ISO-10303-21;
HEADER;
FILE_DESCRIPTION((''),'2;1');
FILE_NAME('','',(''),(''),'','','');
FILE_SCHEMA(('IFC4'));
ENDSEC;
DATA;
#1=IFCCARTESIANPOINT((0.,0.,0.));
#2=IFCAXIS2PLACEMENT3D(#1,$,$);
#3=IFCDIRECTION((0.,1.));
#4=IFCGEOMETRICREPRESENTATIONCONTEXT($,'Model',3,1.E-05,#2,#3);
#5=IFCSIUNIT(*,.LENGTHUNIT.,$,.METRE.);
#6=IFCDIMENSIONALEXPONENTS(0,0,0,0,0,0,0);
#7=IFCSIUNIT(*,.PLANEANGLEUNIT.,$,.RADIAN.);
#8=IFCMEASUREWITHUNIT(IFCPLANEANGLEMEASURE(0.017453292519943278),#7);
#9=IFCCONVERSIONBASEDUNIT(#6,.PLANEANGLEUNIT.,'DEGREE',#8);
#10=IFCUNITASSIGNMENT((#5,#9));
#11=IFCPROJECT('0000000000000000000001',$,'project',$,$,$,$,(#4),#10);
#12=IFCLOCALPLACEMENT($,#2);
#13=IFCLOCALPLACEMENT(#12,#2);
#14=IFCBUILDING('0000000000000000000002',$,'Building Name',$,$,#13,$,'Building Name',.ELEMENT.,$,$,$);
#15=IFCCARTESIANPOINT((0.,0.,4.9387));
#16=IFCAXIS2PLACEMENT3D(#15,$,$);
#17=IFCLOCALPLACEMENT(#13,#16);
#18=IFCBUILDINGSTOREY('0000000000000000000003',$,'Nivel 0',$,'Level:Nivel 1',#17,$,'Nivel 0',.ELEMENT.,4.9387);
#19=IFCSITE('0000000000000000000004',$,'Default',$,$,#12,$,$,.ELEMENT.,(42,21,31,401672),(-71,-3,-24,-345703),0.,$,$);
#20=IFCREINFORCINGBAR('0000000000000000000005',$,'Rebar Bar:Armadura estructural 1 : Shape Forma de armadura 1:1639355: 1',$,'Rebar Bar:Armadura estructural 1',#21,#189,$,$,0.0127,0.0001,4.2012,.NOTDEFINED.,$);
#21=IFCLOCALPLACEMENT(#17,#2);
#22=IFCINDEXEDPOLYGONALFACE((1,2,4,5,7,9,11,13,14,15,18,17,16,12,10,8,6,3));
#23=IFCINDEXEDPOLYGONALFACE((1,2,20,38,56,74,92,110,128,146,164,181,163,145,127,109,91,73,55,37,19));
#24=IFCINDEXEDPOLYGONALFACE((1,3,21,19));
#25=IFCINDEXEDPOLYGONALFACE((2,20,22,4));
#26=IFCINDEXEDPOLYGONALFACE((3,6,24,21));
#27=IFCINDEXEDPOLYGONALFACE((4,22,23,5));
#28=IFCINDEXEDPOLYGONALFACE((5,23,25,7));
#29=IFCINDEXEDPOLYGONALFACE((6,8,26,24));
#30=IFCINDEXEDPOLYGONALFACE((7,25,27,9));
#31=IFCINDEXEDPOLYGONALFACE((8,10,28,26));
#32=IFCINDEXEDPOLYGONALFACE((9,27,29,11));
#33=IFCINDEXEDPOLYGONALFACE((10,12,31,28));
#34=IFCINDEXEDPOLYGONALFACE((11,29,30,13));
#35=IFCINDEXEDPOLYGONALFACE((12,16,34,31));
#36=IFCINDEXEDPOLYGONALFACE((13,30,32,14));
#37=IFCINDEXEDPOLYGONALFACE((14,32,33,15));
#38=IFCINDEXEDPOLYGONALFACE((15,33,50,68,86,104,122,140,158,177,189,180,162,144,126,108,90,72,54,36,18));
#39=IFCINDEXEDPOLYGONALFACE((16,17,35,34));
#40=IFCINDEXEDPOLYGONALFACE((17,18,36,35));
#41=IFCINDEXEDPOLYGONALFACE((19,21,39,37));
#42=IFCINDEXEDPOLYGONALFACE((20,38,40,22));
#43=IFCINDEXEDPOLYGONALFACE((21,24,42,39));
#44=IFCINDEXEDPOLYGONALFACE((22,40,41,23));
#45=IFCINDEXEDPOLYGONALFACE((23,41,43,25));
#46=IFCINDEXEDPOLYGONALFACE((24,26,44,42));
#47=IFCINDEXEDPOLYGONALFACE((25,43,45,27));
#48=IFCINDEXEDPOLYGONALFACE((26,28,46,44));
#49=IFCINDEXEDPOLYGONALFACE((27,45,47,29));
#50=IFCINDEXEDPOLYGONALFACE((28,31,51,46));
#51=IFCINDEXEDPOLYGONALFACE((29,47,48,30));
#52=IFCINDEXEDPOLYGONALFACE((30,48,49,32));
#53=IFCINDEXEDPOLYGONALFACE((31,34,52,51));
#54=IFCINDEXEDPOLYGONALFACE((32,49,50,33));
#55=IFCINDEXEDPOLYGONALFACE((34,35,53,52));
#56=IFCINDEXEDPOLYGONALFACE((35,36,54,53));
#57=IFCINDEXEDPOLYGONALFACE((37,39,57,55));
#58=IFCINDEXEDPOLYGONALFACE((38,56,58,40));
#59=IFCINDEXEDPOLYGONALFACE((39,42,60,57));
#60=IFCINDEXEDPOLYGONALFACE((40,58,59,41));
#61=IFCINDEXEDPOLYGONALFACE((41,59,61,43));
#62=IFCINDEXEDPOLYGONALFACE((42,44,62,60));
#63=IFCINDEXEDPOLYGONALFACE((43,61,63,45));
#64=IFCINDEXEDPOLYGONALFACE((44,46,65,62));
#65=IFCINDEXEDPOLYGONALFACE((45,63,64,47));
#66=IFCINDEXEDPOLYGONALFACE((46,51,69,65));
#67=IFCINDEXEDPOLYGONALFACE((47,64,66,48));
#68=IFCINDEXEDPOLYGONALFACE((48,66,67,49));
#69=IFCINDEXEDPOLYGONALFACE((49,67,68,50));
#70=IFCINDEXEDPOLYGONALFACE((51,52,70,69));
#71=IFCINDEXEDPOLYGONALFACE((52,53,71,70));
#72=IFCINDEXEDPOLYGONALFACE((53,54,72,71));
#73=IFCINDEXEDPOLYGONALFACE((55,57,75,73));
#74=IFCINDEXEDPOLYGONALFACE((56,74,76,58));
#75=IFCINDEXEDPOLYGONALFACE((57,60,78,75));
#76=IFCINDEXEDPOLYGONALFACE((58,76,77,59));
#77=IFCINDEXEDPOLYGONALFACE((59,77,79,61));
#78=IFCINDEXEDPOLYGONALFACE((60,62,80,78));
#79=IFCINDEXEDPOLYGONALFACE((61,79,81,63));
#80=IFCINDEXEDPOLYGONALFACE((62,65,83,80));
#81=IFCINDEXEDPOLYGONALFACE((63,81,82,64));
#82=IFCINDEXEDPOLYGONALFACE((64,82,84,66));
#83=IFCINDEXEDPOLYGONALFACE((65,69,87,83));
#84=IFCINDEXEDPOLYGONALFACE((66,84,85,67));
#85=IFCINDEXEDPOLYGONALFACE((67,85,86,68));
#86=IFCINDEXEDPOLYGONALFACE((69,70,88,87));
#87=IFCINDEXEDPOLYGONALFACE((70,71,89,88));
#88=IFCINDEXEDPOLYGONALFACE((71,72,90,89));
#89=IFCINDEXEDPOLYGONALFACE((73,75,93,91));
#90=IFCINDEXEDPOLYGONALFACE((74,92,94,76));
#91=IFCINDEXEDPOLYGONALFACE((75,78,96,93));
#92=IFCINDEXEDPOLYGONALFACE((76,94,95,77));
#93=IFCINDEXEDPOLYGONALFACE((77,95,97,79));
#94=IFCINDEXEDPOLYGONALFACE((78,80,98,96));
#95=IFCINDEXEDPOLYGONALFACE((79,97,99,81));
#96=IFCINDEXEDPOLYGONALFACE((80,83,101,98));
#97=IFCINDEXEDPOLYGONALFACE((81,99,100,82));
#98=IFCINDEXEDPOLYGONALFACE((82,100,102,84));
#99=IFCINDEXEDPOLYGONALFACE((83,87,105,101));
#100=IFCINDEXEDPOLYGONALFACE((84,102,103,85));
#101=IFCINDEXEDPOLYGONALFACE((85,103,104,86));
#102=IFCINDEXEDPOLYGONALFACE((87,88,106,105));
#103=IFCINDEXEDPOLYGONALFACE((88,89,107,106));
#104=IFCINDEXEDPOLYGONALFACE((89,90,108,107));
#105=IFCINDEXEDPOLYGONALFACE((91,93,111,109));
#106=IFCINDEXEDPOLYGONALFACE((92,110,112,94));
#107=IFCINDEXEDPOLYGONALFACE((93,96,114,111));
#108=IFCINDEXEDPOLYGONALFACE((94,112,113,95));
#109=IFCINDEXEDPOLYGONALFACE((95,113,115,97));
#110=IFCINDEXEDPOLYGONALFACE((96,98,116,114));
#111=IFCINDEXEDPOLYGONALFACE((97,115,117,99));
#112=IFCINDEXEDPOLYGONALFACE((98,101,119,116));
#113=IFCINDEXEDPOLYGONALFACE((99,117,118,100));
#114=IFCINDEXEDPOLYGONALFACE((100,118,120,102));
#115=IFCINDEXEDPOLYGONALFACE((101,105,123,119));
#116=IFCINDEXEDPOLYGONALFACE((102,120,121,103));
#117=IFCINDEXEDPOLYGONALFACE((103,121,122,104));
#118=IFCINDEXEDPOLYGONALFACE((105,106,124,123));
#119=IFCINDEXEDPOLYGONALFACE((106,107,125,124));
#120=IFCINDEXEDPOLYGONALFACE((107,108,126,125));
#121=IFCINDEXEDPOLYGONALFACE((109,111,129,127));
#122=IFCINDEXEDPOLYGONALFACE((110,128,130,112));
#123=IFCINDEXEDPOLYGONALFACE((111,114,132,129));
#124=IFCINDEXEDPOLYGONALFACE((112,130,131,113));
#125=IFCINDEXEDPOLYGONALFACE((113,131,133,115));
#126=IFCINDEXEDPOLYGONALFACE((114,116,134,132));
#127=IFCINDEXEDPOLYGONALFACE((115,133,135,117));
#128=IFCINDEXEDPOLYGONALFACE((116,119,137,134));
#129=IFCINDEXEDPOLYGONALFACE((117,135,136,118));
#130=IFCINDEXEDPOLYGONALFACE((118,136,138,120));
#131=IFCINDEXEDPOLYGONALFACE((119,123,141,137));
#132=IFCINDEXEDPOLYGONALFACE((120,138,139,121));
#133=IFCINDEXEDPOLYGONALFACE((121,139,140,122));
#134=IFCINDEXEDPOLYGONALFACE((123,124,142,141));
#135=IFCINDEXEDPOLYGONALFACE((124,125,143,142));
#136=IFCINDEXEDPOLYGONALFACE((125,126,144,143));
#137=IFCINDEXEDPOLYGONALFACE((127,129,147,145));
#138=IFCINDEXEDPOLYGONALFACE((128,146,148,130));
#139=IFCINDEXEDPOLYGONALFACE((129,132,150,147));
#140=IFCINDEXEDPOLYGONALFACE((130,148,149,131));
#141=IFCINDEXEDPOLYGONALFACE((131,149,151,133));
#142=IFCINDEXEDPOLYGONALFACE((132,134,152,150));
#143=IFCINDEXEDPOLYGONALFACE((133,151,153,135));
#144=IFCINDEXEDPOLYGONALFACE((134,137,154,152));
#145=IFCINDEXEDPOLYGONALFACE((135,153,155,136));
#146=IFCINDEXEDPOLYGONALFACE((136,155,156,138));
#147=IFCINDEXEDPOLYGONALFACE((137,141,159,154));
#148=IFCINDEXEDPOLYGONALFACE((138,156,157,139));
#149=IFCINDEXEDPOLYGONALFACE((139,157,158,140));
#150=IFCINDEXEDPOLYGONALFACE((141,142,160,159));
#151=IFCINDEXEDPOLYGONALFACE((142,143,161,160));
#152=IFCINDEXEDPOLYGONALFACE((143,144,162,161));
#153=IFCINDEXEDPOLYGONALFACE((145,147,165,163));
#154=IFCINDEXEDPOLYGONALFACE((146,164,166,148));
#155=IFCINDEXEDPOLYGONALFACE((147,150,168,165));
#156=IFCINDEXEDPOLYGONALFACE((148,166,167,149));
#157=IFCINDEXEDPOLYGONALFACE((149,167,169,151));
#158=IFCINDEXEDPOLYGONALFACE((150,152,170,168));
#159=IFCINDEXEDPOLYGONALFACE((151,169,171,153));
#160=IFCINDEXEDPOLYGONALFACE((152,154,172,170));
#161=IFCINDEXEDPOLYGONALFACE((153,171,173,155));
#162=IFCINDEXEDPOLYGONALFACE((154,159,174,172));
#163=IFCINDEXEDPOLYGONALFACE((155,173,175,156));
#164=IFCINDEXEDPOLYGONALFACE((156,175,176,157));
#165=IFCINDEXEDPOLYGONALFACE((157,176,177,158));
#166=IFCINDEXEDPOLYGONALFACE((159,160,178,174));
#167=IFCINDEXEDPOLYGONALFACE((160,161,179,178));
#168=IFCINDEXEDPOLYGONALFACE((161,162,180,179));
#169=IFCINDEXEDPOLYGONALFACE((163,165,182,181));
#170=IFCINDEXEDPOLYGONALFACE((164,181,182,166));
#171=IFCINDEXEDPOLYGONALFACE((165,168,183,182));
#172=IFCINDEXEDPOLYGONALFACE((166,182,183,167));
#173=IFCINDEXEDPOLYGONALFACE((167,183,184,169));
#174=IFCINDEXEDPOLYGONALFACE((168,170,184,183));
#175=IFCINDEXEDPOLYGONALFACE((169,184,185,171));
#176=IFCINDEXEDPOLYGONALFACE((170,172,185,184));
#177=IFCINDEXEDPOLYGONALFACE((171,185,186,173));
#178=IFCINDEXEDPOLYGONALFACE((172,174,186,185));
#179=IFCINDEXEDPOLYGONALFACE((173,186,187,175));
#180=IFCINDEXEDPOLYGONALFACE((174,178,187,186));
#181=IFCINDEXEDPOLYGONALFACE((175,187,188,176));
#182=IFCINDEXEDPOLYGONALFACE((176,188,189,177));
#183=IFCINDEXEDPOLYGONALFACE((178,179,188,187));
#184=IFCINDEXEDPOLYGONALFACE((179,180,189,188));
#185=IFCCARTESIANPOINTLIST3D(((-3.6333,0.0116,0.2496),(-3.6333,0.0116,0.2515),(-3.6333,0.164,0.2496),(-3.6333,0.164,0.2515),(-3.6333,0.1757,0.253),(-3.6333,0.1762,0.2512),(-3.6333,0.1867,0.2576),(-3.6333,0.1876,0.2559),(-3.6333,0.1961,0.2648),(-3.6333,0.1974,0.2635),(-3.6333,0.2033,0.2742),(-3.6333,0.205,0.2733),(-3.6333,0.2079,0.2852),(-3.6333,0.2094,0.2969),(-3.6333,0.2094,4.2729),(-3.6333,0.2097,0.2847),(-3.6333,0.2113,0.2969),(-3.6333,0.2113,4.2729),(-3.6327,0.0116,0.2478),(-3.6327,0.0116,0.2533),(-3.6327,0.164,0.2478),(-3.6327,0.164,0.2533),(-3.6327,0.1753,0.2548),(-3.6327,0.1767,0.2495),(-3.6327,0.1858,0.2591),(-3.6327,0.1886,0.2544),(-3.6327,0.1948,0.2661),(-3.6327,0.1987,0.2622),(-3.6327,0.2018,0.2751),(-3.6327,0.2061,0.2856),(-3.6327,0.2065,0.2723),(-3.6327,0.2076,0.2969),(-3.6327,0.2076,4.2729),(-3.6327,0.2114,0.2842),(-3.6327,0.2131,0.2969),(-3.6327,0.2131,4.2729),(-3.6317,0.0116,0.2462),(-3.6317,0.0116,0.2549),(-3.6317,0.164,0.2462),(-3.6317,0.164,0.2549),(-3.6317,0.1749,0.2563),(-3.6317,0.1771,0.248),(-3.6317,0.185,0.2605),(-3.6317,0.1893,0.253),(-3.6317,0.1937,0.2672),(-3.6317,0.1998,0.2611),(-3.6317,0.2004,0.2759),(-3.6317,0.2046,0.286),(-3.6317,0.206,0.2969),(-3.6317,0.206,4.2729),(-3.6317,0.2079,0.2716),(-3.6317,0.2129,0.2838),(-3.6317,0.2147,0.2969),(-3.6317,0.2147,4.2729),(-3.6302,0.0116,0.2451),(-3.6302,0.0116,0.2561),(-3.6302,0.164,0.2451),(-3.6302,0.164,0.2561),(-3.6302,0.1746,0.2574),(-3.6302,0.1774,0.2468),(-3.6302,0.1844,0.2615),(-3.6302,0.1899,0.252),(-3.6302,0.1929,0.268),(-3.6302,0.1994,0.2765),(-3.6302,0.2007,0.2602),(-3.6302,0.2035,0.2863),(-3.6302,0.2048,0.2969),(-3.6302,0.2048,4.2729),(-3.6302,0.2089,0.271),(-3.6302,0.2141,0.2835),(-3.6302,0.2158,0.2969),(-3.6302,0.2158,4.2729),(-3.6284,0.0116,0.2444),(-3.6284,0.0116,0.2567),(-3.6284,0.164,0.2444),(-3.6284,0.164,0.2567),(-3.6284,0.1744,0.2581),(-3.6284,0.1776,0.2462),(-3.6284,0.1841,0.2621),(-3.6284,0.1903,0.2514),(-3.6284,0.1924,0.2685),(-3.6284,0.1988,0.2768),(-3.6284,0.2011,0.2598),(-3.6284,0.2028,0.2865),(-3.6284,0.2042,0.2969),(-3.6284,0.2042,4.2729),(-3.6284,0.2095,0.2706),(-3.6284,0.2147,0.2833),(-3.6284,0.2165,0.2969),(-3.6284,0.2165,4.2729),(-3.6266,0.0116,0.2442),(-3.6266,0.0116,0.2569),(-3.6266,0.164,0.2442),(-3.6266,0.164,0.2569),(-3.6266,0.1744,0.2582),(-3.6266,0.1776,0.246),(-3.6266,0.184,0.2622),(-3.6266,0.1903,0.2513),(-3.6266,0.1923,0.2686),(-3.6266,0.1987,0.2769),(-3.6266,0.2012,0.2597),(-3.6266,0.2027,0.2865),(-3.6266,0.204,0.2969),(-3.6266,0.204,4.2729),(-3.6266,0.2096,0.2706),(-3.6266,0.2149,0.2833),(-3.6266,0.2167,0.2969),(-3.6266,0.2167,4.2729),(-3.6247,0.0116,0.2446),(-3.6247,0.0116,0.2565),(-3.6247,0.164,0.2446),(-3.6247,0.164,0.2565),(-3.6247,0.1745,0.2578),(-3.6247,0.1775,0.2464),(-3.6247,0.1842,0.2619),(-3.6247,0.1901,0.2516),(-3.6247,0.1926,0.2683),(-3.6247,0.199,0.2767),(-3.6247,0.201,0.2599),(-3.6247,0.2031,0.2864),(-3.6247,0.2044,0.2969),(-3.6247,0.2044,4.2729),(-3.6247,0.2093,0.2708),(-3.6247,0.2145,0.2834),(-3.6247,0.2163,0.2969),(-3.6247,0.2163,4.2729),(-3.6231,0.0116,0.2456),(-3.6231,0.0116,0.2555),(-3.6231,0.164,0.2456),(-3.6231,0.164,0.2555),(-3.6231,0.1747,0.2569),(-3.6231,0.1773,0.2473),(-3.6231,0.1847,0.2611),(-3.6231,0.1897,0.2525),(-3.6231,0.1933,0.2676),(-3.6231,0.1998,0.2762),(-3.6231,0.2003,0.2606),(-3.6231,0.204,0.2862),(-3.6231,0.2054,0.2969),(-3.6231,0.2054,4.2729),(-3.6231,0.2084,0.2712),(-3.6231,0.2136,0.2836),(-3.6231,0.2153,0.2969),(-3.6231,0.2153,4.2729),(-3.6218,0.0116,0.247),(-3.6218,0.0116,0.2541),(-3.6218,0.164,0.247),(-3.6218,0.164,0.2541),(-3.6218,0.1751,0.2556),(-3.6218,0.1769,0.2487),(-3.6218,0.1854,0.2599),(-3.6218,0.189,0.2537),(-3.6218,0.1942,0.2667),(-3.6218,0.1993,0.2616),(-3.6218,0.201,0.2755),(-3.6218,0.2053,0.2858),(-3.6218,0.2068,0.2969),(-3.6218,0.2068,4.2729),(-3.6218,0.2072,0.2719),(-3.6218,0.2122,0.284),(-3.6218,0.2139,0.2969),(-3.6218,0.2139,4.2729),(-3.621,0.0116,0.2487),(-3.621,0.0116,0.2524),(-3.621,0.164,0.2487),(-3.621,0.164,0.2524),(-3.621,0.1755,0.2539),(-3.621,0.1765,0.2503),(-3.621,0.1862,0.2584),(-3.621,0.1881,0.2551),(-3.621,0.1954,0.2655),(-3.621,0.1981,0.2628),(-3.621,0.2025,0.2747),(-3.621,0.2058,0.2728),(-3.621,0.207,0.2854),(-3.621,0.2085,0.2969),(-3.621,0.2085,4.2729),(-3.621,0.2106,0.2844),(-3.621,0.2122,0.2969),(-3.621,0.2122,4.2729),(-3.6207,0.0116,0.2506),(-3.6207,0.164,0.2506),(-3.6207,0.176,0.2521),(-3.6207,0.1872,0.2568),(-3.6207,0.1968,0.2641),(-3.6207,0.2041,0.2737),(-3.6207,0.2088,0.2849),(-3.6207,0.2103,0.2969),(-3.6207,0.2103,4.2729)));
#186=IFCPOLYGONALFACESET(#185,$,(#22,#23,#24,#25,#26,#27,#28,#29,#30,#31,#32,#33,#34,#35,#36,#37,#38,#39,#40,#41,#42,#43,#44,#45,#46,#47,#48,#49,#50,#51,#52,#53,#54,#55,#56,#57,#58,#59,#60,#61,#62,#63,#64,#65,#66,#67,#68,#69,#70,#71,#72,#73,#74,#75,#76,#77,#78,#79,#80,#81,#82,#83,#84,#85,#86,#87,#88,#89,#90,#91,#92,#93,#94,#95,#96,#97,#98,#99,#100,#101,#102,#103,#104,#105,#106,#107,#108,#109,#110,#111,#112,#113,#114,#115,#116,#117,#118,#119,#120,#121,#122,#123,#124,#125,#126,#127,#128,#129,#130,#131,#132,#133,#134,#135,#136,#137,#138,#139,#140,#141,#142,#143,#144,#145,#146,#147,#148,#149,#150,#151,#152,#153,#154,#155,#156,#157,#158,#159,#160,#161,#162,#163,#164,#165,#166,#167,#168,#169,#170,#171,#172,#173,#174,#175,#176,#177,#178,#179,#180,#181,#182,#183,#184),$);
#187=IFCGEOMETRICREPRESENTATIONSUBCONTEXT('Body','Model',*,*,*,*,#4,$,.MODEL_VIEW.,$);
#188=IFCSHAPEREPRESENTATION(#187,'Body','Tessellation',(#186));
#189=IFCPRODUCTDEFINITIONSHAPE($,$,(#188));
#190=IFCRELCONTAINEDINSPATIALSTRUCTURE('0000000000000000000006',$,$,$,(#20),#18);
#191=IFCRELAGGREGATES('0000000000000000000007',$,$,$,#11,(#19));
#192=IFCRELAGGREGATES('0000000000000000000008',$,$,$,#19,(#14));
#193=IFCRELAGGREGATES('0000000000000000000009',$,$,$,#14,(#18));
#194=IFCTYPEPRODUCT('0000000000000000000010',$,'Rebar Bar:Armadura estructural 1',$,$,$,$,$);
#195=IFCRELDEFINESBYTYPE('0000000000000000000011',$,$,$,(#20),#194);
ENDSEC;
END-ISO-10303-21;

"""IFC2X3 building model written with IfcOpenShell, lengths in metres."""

from ifc_helpers import new_model, entity, si_unit, converted_unit, direction, frame, origin, place, context, subcontext, project, spatial, type_object, element, save


model = new_model("IFC2X3")

# Units and contexts
model_context = context("Model", 3, precision=1e-05, world=origin(), true_north=direction((0.0, 1.0)))
body_context = subcontext(model_context, "Body", "Model", "MODEL_VIEW")
ifc_project = project(units=[si_unit("LENGTHUNIT", "METRE"), converted_unit("PLANEANGLEUNIT", "DEGREE", entity("IfcPlaneAngleMeasure", 0.017453292519943278), si_unit("PLANEANGLEUNIT", "RADIAN"), dimensions=[0, 0, 0, 0, 0, 0, 0])], contexts=[model_context])

# Site, building, storey
site_placement = place(None, origin())
site = spatial("IfcSite", under=ifc_project, at=site_placement, Name="Default", CompositionType="ELEMENT", RefLatitude=(42, 21, 31, 401672), RefLongitude=(-71, -3, -24, -345703), RefElevation=0.0)
building_placement = place(site_placement, origin())
building = spatial("IfcBuilding", under=site, at=building_placement, Name="Building Name", LongName="Building Name", CompositionType="ELEMENT")
storey_placement = place(building_placement, frame((0.0, 0.0, 4.9387)))
storey = spatial("IfcBuildingStorey", under=building, at=storey_placement, Name="Nivel 0", ObjectType="Level:Nivel 1", LongName="Nivel 0", CompositionType="ELEMENT", Elevation=4.9387)

# Reinforcing bar
type_product = type_object("IfcTypeProduct", Name="Rebar Bar:Armadura estructural 1")
reinforcing_bar_1_placement = place(storey_placement, origin())
element("IfcReinforcingBar", 1, at=reinforcing_bar_1_placement, inside=storey, type_object=type_product, Name="Rebar Bar:Armadura estructural 1 : Shape Forma de armadura 1:1639355: 1", ObjectType="Rebar Bar:Armadura estructural 1", BarLength=4.2012, BarRole="NOTDEFINED", CrossSectionArea=0.0001, NominalDiameter=0.0127, context=body_context, shape_type="AdvancedSweptSolid", body=[
    entity("IfcSweptDiskSolid", entity("IfcCompositeCurve", [entity("IfcCompositeCurveSegment", "CONTINUOUS", True, entity("IfcPolyline", [entity("IfcCartesianPoint", [-3.627, 0.0116, 0.2506]), entity("IfcCartesianPoint", [-3.627, 0.164, 0.2506])])), entity("IfcCompositeCurveSegment", "CONTINUOUS", True, entity("IfcTrimmedCurve", entity("IfcCircle", entity("IfcAxis2Placement3D", entity("IfcCartesianPoint", [-3.627, 0.164, 0.2969]), entity("IfcDirection", [1.0, 0.0, 0.0]), entity("IfcDirection", [0.0, 1.0, 0.0])), 0.0464), [entity("IfcParameterValue", 270.0)], [entity("IfcParameterValue", 360.0)], True, "PARAMETER")), entity("IfcCompositeCurveSegment", "CONTINUOUS", True, entity("IfcPolyline", [entity("IfcCartesianPoint", [-3.627, 0.2103, 0.2969]), entity("IfcCartesianPoint", [-3.627, 0.2103, 4.2729])]))], False), 0.0063, None, 0.0, 92.0),
])

save(model, "model.ifc")
